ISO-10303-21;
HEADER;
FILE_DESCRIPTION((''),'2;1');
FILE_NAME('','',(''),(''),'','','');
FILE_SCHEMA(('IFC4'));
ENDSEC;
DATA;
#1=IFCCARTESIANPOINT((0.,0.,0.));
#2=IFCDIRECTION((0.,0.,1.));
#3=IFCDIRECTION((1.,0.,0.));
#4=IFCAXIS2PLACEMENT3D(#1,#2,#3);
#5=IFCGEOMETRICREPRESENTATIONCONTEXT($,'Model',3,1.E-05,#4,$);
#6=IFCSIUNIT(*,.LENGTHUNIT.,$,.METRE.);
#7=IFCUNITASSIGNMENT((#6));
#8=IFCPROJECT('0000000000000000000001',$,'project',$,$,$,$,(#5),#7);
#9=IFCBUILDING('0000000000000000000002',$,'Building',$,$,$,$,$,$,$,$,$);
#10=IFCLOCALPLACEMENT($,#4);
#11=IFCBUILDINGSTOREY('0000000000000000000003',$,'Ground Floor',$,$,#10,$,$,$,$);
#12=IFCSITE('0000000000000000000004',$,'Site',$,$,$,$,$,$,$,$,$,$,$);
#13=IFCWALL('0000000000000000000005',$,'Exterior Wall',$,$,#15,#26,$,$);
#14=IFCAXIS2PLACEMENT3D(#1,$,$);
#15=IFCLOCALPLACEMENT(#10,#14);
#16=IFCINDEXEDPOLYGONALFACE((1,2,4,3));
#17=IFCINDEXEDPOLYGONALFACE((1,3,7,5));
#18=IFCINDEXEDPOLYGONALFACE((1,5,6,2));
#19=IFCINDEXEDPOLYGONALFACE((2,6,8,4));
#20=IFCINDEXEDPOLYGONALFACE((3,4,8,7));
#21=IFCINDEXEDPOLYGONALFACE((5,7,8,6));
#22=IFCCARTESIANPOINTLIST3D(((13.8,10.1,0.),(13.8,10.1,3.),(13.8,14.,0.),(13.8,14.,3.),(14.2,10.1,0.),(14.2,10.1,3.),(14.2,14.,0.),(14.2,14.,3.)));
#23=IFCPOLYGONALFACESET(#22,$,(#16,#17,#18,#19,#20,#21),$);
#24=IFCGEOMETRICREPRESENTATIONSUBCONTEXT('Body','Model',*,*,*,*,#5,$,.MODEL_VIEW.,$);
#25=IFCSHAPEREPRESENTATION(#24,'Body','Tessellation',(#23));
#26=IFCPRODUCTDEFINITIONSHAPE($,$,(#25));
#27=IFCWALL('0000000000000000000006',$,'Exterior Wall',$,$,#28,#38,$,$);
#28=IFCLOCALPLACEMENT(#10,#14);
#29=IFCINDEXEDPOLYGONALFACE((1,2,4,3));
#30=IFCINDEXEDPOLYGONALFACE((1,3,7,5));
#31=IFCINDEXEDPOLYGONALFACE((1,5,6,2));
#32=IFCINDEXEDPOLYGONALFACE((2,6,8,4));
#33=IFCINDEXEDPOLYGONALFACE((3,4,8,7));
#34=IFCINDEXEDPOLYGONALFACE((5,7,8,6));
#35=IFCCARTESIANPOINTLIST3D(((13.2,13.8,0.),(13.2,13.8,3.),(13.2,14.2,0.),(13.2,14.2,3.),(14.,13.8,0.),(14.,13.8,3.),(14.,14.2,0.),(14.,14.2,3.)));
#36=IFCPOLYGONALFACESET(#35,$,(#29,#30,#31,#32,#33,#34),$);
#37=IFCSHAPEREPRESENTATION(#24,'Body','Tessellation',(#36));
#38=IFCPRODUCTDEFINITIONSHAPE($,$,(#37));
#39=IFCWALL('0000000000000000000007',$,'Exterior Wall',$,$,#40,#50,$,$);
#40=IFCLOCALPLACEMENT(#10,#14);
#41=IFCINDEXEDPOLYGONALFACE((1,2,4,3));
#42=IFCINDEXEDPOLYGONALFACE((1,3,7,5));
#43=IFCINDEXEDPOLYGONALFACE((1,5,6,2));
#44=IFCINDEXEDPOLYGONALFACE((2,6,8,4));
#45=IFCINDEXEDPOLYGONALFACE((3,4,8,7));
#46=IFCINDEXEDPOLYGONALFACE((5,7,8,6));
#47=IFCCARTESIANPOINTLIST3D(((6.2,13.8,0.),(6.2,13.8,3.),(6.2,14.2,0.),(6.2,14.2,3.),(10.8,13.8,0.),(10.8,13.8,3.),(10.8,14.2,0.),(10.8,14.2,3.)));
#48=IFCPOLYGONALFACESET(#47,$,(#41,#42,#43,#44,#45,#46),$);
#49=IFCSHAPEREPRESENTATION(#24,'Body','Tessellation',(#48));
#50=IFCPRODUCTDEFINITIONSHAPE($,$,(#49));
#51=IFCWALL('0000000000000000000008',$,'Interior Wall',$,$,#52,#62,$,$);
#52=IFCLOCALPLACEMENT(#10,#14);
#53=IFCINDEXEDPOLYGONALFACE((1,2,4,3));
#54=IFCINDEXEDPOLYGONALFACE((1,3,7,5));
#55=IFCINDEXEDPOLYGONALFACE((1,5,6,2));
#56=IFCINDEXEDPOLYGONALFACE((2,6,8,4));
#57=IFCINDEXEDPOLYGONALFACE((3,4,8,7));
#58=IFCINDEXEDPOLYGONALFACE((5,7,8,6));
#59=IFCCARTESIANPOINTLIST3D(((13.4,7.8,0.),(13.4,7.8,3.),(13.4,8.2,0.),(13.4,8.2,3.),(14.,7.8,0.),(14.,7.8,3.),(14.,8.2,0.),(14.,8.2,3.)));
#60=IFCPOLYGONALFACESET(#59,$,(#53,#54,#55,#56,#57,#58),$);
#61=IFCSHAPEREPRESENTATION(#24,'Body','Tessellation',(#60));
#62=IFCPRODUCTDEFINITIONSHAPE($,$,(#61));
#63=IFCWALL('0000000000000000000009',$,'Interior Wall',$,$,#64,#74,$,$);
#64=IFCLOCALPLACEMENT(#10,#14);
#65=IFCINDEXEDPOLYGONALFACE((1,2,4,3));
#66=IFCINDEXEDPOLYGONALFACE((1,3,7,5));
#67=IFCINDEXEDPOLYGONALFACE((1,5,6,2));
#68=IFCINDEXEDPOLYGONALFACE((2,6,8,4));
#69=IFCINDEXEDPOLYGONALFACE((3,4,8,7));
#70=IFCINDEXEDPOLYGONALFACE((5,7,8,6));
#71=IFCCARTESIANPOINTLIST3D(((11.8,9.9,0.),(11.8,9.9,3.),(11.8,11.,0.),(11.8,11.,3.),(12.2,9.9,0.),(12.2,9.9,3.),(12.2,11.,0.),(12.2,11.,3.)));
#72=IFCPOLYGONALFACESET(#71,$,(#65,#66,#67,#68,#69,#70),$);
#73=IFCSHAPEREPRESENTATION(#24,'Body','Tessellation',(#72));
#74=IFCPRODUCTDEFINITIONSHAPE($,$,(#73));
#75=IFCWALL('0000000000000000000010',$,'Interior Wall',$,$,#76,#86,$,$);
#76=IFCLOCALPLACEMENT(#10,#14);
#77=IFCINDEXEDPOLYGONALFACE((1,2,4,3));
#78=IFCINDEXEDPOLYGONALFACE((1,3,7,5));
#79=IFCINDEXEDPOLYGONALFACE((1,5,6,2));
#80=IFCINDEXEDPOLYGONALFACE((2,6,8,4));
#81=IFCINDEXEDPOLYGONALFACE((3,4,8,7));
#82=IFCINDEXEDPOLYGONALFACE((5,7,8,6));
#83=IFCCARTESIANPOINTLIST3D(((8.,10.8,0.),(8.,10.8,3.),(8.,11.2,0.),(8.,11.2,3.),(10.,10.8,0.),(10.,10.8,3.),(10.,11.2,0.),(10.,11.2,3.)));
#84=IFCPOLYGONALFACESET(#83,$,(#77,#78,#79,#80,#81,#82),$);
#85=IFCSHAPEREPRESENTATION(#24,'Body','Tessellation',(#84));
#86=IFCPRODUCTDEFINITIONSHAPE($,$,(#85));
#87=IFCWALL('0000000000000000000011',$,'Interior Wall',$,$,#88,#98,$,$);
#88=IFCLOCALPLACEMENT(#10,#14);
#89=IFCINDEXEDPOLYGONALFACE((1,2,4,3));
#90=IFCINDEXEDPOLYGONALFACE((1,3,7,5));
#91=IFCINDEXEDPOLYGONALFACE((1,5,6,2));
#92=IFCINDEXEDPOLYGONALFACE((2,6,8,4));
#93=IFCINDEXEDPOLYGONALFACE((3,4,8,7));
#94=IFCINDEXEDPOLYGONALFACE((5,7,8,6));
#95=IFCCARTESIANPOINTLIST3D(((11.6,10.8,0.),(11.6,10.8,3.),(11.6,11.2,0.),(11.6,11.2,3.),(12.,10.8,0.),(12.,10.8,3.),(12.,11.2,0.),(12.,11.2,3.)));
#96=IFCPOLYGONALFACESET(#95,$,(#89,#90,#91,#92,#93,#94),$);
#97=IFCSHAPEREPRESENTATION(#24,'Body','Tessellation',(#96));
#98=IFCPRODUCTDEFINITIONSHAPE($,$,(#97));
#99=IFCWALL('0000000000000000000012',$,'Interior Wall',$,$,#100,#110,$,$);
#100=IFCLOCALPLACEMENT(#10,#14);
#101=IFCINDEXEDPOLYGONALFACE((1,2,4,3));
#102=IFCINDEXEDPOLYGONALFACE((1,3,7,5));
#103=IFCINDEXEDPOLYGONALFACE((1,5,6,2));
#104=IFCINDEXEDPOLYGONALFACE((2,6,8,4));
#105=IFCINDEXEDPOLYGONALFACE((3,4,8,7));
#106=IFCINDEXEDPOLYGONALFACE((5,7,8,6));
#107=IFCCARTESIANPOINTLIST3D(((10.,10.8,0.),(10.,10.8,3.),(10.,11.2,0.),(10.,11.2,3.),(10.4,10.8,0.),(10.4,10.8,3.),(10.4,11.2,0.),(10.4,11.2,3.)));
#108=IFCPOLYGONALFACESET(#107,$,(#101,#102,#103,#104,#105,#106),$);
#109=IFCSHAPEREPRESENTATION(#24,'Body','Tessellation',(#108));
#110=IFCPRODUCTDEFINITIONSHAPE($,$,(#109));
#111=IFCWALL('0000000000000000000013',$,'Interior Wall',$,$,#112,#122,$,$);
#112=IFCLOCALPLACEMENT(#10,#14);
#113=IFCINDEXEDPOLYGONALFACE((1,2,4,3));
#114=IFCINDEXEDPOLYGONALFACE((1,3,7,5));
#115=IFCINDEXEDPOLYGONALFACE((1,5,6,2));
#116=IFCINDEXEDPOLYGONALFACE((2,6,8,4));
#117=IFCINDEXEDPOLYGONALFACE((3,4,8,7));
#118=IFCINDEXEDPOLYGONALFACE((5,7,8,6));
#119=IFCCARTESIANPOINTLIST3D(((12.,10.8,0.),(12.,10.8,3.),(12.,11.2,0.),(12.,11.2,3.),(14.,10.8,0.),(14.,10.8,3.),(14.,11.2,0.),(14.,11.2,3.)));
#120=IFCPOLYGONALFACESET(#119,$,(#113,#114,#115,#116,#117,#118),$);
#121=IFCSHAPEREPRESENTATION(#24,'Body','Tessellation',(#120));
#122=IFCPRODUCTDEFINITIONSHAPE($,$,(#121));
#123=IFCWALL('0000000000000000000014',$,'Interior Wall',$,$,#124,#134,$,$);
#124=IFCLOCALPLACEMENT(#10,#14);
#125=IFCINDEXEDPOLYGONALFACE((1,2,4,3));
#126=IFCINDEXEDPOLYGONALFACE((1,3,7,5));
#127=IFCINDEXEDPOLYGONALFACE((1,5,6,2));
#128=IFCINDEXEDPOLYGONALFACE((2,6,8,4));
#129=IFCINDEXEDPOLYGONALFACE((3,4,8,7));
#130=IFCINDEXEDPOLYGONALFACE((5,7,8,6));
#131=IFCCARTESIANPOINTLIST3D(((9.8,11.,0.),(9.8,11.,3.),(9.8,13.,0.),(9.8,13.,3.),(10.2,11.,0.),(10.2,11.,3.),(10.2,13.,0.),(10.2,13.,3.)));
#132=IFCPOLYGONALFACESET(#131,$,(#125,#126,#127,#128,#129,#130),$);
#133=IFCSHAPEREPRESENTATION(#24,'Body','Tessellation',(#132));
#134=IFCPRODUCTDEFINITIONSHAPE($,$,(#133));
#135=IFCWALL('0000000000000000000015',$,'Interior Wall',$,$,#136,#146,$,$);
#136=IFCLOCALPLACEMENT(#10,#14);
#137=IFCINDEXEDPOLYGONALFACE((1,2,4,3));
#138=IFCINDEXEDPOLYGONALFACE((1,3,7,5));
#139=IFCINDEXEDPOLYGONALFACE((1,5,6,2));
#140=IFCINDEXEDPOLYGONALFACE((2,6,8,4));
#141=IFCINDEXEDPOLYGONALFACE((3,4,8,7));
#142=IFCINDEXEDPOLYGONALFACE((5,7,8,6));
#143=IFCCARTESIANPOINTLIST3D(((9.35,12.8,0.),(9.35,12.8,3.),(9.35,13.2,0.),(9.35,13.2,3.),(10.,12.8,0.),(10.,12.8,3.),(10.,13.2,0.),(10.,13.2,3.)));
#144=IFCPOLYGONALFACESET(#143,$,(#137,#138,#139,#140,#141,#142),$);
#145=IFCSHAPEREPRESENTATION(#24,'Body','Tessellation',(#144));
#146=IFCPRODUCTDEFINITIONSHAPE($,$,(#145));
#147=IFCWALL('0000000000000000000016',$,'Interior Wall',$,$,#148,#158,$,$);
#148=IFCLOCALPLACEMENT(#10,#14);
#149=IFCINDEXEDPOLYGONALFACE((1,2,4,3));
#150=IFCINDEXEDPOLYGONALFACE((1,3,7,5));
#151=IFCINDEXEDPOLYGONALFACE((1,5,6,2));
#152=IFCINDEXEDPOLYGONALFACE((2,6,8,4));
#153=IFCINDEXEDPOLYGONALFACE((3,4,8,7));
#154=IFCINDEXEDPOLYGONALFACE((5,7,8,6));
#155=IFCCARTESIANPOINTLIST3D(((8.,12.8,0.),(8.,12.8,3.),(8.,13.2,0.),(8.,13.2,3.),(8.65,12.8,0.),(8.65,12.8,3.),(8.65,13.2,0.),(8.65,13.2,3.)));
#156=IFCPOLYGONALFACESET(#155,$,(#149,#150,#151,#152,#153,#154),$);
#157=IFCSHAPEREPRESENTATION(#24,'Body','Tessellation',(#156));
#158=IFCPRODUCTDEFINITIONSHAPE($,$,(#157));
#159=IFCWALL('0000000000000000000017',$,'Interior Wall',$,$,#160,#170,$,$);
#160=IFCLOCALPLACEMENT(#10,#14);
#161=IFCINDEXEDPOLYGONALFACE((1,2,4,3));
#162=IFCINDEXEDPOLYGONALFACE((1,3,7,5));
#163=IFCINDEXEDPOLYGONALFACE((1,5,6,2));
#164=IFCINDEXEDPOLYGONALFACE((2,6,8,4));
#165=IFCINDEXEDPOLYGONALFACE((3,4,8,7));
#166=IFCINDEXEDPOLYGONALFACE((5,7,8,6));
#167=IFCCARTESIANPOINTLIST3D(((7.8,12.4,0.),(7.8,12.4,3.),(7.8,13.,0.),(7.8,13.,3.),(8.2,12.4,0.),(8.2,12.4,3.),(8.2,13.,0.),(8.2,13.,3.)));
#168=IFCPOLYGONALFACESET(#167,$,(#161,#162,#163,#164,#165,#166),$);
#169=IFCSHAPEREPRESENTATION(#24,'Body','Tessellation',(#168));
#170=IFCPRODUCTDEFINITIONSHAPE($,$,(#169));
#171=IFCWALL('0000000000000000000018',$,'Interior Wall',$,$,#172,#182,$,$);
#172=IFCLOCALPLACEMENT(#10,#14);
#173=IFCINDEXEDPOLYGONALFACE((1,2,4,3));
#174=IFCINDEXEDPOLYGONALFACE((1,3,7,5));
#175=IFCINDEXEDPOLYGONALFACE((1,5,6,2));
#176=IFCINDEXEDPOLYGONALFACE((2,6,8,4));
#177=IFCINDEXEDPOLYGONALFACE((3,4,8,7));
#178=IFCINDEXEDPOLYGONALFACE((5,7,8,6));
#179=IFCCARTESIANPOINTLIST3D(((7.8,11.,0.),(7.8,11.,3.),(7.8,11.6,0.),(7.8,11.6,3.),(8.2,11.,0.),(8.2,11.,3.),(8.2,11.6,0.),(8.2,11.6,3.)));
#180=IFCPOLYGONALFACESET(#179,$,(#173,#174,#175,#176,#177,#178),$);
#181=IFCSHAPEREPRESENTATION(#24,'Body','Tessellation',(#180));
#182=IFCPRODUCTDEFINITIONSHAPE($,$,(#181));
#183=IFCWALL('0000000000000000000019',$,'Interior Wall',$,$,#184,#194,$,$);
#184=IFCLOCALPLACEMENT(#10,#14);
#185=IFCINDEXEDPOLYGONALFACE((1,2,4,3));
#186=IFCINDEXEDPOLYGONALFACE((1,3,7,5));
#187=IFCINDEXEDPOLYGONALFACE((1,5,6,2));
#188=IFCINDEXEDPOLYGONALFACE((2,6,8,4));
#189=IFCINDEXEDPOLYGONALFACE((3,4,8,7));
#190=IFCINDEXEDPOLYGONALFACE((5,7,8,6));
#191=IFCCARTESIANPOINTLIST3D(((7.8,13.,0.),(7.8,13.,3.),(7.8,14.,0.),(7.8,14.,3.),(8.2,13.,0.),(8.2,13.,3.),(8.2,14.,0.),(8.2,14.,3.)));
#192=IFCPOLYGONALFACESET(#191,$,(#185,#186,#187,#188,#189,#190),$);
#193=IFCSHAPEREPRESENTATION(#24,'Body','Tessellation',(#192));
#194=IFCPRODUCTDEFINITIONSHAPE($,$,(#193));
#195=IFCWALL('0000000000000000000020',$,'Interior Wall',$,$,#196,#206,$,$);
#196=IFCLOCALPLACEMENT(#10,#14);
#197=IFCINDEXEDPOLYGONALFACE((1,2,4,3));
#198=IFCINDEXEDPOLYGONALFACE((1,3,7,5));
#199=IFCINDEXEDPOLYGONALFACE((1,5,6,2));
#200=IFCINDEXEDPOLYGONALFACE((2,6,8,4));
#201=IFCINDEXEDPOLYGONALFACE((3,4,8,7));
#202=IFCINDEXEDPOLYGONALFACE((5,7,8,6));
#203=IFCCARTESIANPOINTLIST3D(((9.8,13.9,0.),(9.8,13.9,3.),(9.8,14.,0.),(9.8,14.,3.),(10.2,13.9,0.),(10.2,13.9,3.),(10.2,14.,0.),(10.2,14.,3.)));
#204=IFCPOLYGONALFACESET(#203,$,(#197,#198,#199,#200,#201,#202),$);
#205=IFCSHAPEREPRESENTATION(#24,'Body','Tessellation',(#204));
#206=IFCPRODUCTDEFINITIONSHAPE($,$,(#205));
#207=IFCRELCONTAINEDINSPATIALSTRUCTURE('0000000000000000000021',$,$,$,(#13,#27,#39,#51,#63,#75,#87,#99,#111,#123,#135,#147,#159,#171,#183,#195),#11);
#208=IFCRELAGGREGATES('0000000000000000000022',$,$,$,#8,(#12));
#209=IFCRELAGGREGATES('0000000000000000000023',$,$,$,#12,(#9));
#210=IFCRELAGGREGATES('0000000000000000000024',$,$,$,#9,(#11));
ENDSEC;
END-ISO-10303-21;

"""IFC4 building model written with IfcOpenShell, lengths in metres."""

from ifc_helpers import new_model, si_unit, frame, origin_with_axes, place, context, subcontext, project, spatial, indexed_curve, outline, extrude, element, save


model = new_model("IFC4")

# Units and contexts
model_context = context("Model", 3, precision=1e-05, world=origin_with_axes())
body_context = subcontext(model_context, "Body", "Model", "MODEL_VIEW")
ifc_project = project(units=[si_unit("LENGTHUNIT", "METRE")], contexts=[model_context])

# Site, building, storey
site = spatial("IfcSite", under=ifc_project, Name="Site")
building = spatial("IfcBuilding", under=site, Name="Building")
storey_placement = place(None, origin_with_axes())
storey = spatial("IfcBuildingStorey", under=building, at=storey_placement, Name="Ground Floor")

# Walls
wall_1_placement = place(storey_placement, frame((14.0, 10.1, 0.0), z_axis=(0.0, 0.0, 1.0), x_axis=(0.0, 1.0, 0.0)))
element("IfcWall", 1, at=wall_1_placement, inside=storey, Name="Exterior Wall", context=body_context, shape_type="SweptSolid", body=[
    extrude(outline(indexed_curve([(0.0, 0.0), (0.0, 0.4), (3.9, 0.4), (3.9, 0.0), (0.0, 0.0)], self_intersect=False)), frame((0.0, -0.2, 0.0), z_axis=(0.0, 0.0, 1.0), x_axis=(1.0, 0.0, 0.0)), (0.0, 0.0, 1.0), 3.0),
])
wall_2_placement = place(storey_placement, frame((14.0, 14.0, 0.0), z_axis=(0.0, 0.0, 1.0), x_axis=(-1.0, 0.0, 0.0)))
element("IfcWall", 2, at=wall_2_placement, inside=storey, Name="Exterior Wall", context=body_context, shape_type="SweptSolid", body=[
    extrude(outline(indexed_curve([(0.0, 0.0), (0.0, 0.4), (0.8, 0.4), (0.8, 0.0), (0.0, 0.0)], self_intersect=False)), frame((0.0, -0.2, 0.0), z_axis=(0.0, 0.0, 1.0), x_axis=(1.0, 0.0, 0.0)), (0.0, 0.0, 1.0), 3.0),
])
wall_3_placement = place(storey_placement, frame((10.8, 14.0, 0.0), z_axis=(0.0, 0.0, 1.0), x_axis=(-1.0, 0.0, 0.0)))
element("IfcWall", 3, at=wall_3_placement, inside=storey, Name="Exterior Wall", context=body_context, shape_type="SweptSolid", body=[
    extrude(outline(indexed_curve([(0.0, 0.0), (0.0, 0.4), (4.6, 0.4), (4.6, 0.0), (0.0, 0.0)], self_intersect=False)), frame((0.0, -0.2, 0.0), z_axis=(0.0, 0.0, 1.0), x_axis=(1.0, 0.0, 0.0)), (0.0, 0.0, 1.0), 3.0),
])
wall_4_placement = place(storey_placement, frame((14.0, 8.0, 0.0), z_axis=(0.0, 0.0, 1.0), x_axis=(-1.0, 0.0, 0.0)))
element("IfcWall", 4, at=wall_4_placement, inside=storey, Name="Interior Wall", context=body_context, shape_type="SweptSolid", body=[
    extrude(outline(indexed_curve([(0.0, 0.0), (0.0, 0.4), (0.6, 0.4), (0.6, 0.0), (0.0, 0.0)], self_intersect=False)), frame((0.0, -0.2, 0.0), z_axis=(0.0, 0.0, 1.0), x_axis=(1.0, 0.0, 0.0)), (0.0, 0.0, 1.0), 3.0),
])
wall_5_placement = place(storey_placement, frame((12.0, 9.9, 0.0), z_axis=(0.0, 0.0, 1.0), x_axis=(0.0, 1.0, 0.0)))
element("IfcWall", 5, at=wall_5_placement, inside=storey, Name="Interior Wall", context=body_context, shape_type="SweptSolid", body=[
    extrude(outline(indexed_curve([(0.0, 0.0), (0.0, 0.4), (1.1, 0.4), (1.1, 0.0), (0.0, 0.0)], self_intersect=False)), frame((0.0, -0.2, 0.0), z_axis=(0.0, 0.0, 1.0), x_axis=(1.0, 0.0, 0.0)), (0.0, 0.0, 1.0), 3.0),
])
wall_6_placement = place(storey_placement, frame((10.0, 11.0, 0.0), z_axis=(0.0, 0.0, 1.0), x_axis=(-1.0, 0.0, 0.0)))
element("IfcWall", 6, at=wall_6_placement, inside=storey, Name="Interior Wall", context=body_context, shape_type="SweptSolid", body=[
    extrude(outline(indexed_curve([(0.0, 0.0), (0.0, 0.4), (2.0, 0.4), (2.0, 0.0), (0.0, 0.0)], self_intersect=False)), frame((0.0, -0.2, 0.0), z_axis=(0.0, 0.0, 1.0), x_axis=(1.0, 0.0, 0.0)), (0.0, 0.0, 1.0), 3.0),
])
for number, where, z_axis, x_axis, name in (
    (7, (12.0, 11.0, 0.0), (0.0, 0.0, 1.0), (-1.0, 0.0, 0.0), "Interior Wall"),
    (8, (10.4, 11.0, 0.0), (0.0, 0.0, 1.0), (-1.0, 0.0, 0.0), "Interior Wall"),
):
    element("IfcWall", number, at=place(storey_placement, frame(where, z_axis=z_axis, x_axis=x_axis)), inside=storey, Name=name, context=body_context, shape_type="SweptSolid", body=[
        extrude(outline(indexed_curve([(0.0, 0.0), (0.0, 0.4), (0.4, 0.4), (0.4, 0.0), (0.0, 0.0)], self_intersect=False)), frame((0.0, -0.2, 0.0), z_axis=(0.0, 0.0, 1.0), x_axis=(1.0, 0.0, 0.0)), (0.0, 0.0, 1.0), 3.0),
    ])
for number, where, z_axis, x_axis, name in (
    (9, (14.0, 11.0, 0.0), (0.0, 0.0, 1.0), (-1.0, 0.0, 0.0), "Interior Wall"),
    (10, (10.0, 11.0, 0.0), (0.0, 0.0, 1.0), (0.0, 1.0, 0.0), "Interior Wall"),
):
    element("IfcWall", number, at=place(storey_placement, frame(where, z_axis=z_axis, x_axis=x_axis)), inside=storey, Name=name, context=body_context, shape_type="SweptSolid", body=[
        extrude(outline(indexed_curve([(0.0, 0.0), (0.0, 0.4), (2.0, 0.4), (2.0, 0.0), (0.0, 0.0)], self_intersect=False)), frame((0.0, -0.2, 0.0), z_axis=(0.0, 0.0, 1.0), x_axis=(1.0, 0.0, 0.0)), (0.0, 0.0, 1.0), 3.0),
    ])
for number, where, z_axis, x_axis, name in (
    (11, (10.0, 13.0, 0.0), (0.0, 0.0, 1.0), (-1.0, 0.0, 0.0), "Interior Wall"),
    (12, (8.65, 13.0, 0.0), (0.0, 0.0, 1.0), (-1.0, 0.0, 0.0), "Interior Wall"),
):
    element("IfcWall", number, at=place(storey_placement, frame(where, z_axis=z_axis, x_axis=x_axis)), inside=storey, Name=name, context=body_context, shape_type="SweptSolid", body=[
        extrude(outline(indexed_curve([(0.0, 0.0), (0.0, 0.4), (0.65, 0.4), (0.65, 0.0), (0.0, 0.0)], self_intersect=False)), frame((0.0, -0.2, 0.0), z_axis=(0.0, 0.0, 1.0), x_axis=(1.0, 0.0, 0.0)), (0.0, 0.0, 1.0), 3.0),
    ])
for number, where, z_axis, x_axis, name in (
    (13, (8.0, 13.0, 0.0), (0.0, 0.0, 1.0), (0.0, -1.0, 0.0), "Interior Wall"),
    (14, (8.0, 11.6, 0.0), (0.0, 0.0, 1.0), (0.0, -1.0, 0.0), "Interior Wall"),
):
    element("IfcWall", number, at=place(storey_placement, frame(where, z_axis=z_axis, x_axis=x_axis)), inside=storey, Name=name, context=body_context, shape_type="SweptSolid", body=[
        extrude(outline(indexed_curve([(0.0, 0.0), (0.0, 0.4), (0.6, 0.4), (0.6, 0.0), (0.0, 0.0)], self_intersect=False)), frame((0.0, -0.2, 0.0), z_axis=(0.0, 0.0, 1.0), x_axis=(1.0, 0.0, 0.0)), (0.0, 0.0, 1.0), 3.0),
    ])
wall_7_placement = place(storey_placement, frame((8.0, 13.0, 0.0), z_axis=(0.0, 0.0, 1.0), x_axis=(0.0, 1.0, 0.0)))
element("IfcWall", 15, at=wall_7_placement, inside=storey, Name="Interior Wall", context=body_context, shape_type="SweptSolid", body=[
    extrude(outline(indexed_curve([(0.0, 0.0), (0.0, 0.4), (1.0, 0.4), (1.0, 0.0), (0.0, 0.0)], self_intersect=False)), frame((0.0, -0.2, 0.0), z_axis=(0.0, 0.0, 1.0), x_axis=(1.0, 0.0, 0.0)), (0.0, 0.0, 1.0), 3.0),
])
for number, where, z_axis, x_axis, name in (
    (16, (10.0, 14.0, 0.0), (0.0, 0.0, 1.0), (0.0, -1.0, 0.0), "Interior Wall"),
):
    element("IfcWall", number, at=place(storey_placement, frame(where, z_axis=z_axis, x_axis=x_axis)), inside=storey, Name=name, context=body_context, shape_type="SweptSolid", body=[
        extrude(outline(indexed_curve([(0.0, 0.0), (0.0, 0.4), (0.1, 0.4), (0.1, 0.0), (0.0, 0.0)], self_intersect=False)), frame((0.0, -0.2, 0.0), z_axis=(0.0, 0.0, 1.0), x_axis=(1.0, 0.0, 0.0)), (0.0, 0.0, 1.0), 3.0),
    ])

save(model, "model.ifc")
